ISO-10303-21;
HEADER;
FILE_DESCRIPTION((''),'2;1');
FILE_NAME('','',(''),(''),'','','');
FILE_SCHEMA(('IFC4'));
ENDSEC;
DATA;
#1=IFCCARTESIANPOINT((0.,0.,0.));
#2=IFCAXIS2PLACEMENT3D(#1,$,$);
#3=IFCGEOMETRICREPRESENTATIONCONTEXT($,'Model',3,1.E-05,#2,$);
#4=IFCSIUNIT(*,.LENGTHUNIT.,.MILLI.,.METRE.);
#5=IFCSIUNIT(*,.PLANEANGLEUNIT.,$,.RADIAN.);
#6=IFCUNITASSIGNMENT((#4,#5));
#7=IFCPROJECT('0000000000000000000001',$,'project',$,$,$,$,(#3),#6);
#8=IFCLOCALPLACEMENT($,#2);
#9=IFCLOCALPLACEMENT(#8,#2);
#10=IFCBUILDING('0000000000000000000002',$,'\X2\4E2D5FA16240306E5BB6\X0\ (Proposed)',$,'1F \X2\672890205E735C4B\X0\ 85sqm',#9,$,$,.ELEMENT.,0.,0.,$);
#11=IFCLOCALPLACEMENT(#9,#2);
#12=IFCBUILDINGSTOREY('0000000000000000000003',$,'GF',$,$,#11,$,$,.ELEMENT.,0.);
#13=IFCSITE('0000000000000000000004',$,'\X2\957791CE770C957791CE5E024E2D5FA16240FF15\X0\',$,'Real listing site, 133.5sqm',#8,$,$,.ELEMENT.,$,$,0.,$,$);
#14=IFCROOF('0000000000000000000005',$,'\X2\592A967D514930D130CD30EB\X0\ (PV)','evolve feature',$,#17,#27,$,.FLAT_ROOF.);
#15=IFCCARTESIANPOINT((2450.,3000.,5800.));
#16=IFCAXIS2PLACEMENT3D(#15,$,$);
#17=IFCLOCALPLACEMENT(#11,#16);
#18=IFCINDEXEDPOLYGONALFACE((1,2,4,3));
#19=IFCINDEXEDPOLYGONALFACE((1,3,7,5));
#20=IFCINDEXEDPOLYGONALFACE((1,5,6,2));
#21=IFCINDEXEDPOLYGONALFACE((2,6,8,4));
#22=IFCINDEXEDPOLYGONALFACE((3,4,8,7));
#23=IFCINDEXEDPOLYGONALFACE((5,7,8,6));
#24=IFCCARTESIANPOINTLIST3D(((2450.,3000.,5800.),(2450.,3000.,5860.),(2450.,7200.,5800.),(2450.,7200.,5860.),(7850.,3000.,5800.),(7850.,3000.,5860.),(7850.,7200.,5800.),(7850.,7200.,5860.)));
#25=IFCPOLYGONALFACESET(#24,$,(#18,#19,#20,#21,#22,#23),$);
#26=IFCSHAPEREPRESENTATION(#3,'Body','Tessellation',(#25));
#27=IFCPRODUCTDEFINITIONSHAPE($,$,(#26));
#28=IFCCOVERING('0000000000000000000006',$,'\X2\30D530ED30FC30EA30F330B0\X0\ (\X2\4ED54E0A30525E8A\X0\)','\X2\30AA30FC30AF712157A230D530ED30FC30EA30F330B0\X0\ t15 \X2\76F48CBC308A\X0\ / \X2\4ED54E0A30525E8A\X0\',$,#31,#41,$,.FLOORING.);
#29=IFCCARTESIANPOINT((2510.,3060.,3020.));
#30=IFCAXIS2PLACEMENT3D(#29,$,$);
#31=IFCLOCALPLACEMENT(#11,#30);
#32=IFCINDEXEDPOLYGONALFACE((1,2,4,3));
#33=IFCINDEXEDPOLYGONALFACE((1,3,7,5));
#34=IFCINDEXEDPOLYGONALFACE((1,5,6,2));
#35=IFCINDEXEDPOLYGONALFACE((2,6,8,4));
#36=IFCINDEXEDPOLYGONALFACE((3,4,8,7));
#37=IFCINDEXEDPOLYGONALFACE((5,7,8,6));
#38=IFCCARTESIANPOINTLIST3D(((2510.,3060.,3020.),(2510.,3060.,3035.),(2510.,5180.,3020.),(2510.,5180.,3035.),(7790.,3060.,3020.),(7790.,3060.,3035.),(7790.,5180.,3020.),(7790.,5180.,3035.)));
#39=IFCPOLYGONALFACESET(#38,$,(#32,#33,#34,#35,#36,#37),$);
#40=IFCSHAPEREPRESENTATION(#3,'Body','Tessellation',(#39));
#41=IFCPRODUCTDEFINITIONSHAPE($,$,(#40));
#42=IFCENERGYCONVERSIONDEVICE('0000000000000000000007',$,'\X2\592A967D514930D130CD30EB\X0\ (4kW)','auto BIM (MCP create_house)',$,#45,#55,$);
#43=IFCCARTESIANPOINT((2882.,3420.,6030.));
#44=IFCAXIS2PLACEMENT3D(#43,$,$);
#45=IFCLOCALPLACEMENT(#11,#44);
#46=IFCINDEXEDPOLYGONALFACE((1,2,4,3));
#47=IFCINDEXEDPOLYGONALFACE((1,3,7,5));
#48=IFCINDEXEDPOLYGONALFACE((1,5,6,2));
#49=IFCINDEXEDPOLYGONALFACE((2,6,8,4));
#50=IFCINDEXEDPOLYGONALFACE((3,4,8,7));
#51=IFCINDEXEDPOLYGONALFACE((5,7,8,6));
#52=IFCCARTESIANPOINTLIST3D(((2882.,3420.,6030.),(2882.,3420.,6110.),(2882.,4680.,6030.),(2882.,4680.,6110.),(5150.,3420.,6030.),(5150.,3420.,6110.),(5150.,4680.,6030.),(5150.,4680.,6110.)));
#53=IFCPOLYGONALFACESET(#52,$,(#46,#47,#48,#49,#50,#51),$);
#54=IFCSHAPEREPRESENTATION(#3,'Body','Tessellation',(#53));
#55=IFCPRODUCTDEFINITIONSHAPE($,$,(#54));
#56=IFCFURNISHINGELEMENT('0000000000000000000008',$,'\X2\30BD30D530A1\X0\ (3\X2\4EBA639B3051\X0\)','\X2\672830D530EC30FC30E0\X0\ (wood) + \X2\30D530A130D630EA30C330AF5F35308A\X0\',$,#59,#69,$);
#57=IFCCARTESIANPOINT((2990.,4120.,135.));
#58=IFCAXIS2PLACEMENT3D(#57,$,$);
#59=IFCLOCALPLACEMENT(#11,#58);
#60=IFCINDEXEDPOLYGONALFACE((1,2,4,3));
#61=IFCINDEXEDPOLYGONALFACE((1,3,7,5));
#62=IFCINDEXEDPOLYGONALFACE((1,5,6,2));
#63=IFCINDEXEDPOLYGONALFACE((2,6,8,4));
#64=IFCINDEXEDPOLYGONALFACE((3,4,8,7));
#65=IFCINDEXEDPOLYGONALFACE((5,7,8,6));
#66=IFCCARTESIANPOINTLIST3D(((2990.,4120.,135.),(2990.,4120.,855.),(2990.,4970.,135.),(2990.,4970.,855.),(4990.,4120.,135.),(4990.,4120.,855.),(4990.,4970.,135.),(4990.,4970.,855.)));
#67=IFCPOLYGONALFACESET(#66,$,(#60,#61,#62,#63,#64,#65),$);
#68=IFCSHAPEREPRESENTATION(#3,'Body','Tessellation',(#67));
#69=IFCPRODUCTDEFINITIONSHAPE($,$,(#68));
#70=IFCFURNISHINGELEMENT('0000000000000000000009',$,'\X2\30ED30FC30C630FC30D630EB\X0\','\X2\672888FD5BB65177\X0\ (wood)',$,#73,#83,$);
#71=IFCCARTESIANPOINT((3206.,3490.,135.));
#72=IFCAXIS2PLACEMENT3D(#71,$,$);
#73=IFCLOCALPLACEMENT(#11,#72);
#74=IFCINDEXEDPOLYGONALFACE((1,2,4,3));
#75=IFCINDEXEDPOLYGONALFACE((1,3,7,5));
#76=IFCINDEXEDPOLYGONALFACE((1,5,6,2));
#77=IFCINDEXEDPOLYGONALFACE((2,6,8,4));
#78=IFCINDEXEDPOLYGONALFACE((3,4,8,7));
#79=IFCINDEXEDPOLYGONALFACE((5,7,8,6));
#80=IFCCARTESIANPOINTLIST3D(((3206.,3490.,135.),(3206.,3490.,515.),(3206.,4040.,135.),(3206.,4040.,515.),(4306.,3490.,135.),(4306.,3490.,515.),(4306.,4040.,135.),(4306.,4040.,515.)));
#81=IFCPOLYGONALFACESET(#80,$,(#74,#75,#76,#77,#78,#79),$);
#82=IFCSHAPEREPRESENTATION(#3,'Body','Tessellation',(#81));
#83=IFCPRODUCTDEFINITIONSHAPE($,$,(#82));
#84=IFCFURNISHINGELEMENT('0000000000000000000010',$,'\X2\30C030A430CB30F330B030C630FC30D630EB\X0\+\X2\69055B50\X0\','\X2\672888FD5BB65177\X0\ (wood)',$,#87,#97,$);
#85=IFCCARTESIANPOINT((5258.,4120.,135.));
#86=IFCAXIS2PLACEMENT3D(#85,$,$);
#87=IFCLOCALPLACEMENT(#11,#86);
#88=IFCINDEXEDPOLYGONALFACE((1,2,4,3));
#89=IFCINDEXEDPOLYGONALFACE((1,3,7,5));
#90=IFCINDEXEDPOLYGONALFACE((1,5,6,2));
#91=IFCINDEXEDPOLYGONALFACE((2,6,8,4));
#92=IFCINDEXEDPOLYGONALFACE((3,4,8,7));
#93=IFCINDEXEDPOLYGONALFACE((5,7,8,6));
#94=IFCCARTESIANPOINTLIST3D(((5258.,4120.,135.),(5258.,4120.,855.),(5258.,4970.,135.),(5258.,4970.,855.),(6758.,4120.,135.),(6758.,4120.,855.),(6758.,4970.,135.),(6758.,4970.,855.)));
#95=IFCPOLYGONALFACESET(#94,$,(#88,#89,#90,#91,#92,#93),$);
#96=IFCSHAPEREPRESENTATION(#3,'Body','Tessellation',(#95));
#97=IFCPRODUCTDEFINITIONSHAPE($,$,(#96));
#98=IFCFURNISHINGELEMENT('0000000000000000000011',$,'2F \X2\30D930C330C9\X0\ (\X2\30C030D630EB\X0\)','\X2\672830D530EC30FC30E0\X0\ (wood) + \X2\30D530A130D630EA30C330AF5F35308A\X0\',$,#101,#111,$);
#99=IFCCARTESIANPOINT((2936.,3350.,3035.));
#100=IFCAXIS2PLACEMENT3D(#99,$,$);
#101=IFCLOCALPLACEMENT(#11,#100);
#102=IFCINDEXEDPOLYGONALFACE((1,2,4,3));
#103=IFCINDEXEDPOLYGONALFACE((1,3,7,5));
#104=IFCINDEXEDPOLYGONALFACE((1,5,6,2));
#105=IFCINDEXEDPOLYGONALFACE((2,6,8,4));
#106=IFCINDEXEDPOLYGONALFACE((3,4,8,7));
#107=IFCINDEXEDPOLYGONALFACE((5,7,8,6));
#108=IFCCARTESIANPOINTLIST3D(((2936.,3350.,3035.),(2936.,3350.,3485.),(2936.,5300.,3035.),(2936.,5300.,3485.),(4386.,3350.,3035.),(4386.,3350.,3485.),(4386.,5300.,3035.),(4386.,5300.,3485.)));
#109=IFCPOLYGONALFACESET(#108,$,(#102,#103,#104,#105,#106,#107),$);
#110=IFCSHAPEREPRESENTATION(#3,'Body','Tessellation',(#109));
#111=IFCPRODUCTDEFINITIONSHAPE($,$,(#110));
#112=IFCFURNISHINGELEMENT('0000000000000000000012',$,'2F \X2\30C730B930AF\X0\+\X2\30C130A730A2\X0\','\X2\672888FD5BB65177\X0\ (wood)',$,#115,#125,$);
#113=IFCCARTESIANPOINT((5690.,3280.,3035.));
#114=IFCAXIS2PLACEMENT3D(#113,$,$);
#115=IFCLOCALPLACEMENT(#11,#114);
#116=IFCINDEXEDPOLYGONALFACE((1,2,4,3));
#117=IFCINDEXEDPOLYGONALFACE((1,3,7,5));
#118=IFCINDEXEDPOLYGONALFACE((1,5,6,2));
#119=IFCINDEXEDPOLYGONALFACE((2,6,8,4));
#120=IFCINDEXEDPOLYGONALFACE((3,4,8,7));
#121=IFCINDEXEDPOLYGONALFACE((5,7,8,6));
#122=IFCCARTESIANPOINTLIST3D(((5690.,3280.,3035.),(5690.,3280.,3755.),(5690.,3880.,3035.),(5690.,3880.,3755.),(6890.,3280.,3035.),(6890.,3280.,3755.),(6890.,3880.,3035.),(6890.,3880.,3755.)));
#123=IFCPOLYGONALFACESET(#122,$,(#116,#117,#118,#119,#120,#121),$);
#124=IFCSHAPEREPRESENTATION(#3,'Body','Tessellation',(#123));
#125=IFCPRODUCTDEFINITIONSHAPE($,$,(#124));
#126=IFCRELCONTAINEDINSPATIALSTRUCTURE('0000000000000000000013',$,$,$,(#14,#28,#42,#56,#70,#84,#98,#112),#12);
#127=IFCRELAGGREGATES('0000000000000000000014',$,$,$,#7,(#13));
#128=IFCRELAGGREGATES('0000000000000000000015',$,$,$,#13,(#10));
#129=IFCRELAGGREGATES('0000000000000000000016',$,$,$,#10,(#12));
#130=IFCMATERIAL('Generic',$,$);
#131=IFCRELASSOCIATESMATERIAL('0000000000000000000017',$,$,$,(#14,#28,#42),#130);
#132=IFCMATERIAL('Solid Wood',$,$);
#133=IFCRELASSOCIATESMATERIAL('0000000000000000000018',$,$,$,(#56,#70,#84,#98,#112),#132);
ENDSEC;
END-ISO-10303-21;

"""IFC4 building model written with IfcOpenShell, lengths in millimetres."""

from ifc_helpers import new_model, si_unit, frame, frame_2d, origin, place, context, project, spatial, rectangle, extrude, material, element, save


model = new_model("IFC4")

# Units and contexts
model_context = context("Model", 3, precision=1e-05, world=origin())
ifc_project = project(units=[si_unit("LENGTHUNIT", "METRE", prefix="MILLI"), si_unit("PLANEANGLEUNIT", "RADIAN")], contexts=[model_context])

# Site, building, storey
site_placement = place(None, origin())
site = spatial("IfcSite", under=ifc_project, at=site_placement, Name="長野県長野市中御所５", ObjectType="Real listing site, 133.5sqm", CompositionType="ELEMENT", RefElevation=0.0)
building_placement = place(site_placement, origin())
building = spatial("IfcBuilding", under=site, at=building_placement, Name="中御所の家 (Proposed)", ObjectType="1F 木造平屋 85sqm", CompositionType="ELEMENT", ElevationOfRefHeight=0.0, ElevationOfTerrain=0.0)
storey_placement = place(building_placement, origin())
storey = spatial("IfcBuildingStorey", under=building, at=storey_placement, Name="GF", CompositionType="ELEMENT", Elevation=0.0)

# Shared definitions
ifc_material_1 = material(Name="Solid Wood")

# Roof
ifc_material_2 = material(Name="Generic")
roof_1_placement = place(storey_placement, frame((2450.0, 3000.0, 5800.0)))
element("IfcRoof", 1, at=roof_1_placement, inside=storey, material=ifc_material_2, Name="太陽光パネル (PV)", Description="evolve feature", PredefinedType="FLAT_ROOF", context=model_context, shape_type="SweptSolid", body=[
    extrude(rectangle(XDim=5400.0, YDim=4200.0, at=frame_2d((2700.0, 2100.0))), frame((2450.0, 3000.0, 5800.0)), (0.0, 0.0, 1.0), 60.0),
])

# Covering
covering_placement = place(storey_placement, frame((2510.0, 3060.0, 3020.0)))
element("IfcCovering", 2, at=covering_placement, inside=storey, material=ifc_material_2, Name="フローリング (仕上げ床)", Description="オーク無垢フローリング t15 直貼り / 仕上げ床", PredefinedType="FLOORING", context=model_context, shape_type="SweptSolid", body=[
    extrude(rectangle(XDim=5280.0, YDim=2120.0, at=frame_2d((2640.0, 1060.0))), frame((2510.0, 3060.0, 3020.0)), (0.0, 0.0, 1.0), 15.0),
])

# Energy conversion device
energy_conversion_device_placement = place(storey_placement, frame((2882.0, 3420.0, 6030.0)))
element("IfcEnergyConversionDevice", 3, at=energy_conversion_device_placement, inside=storey, material=ifc_material_2, Name="太陽光パネル (4kW)", Description="auto BIM (MCP create_house)", context=model_context, shape_type="SweptSolid", body=[
    extrude(rectangle(XDim=2268.0, YDim=1260.0, at=frame_2d((1134.0, 630.0))), frame((2882.0, 3420.0, 6030.0)), (0.0, 0.0, 1.0), 80.0),
])

# Furnishing elements
furnishing_1_placement = place(storey_placement, frame((2990.0, 4120.0, 135.0)))
element("IfcFurnishingElement", 4, at=furnishing_1_placement, inside=storey, material=ifc_material_1, Name="ソファ (3人掛け)", Description="木フレーム (wood) + ファブリック張り", context=model_context, shape_type="SweptSolid", body=[
    extrude(rectangle(XDim=2000.0, YDim=850.0, at=frame_2d((1000.0, 425.0))), frame((2990.0, 4120.0, 135.0)), (0.0, 0.0, 1.0), 720.0),
])
furnishing_2_placement = place(storey_placement, frame((3206.0, 3490.0, 135.0)))
element("IfcFurnishingElement", 5, at=furnishing_2_placement, inside=storey, material=ifc_material_1, Name="ローテーブル", Description="木製家具 (wood)", context=model_context, shape_type="SweptSolid", body=[
    extrude(rectangle(XDim=1100.0, YDim=550.0, at=frame_2d((550.0, 275.0))), frame((3206.0, 3490.0, 135.0)), (0.0, 0.0, 1.0), 380.0),
])
furnishing_3_placement = place(storey_placement, frame((5258.0, 4120.0, 135.0)))
element("IfcFurnishingElement", 6, at=furnishing_3_placement, inside=storey, material=ifc_material_1, Name="ダイニングテーブル+椅子", Description="木製家具 (wood)", context=model_context, shape_type="SweptSolid", body=[
    extrude(rectangle(XDim=1500.0, YDim=850.0, at=frame_2d((750.0, 425.0))), frame((5258.0, 4120.0, 135.0)), (0.0, 0.0, 1.0), 720.0),
])
furnishing_4_placement = place(storey_placement, frame((2936.0, 3350.0, 3035.0)))
element("IfcFurnishingElement", 7, at=furnishing_4_placement, inside=storey, material=ifc_material_1, Name="2F ベッド (ダブル)", Description="木フレーム (wood) + ファブリック張り", context=model_context, shape_type="SweptSolid", body=[
    extrude(rectangle(XDim=1450.0, YDim=1950.0, at=frame_2d((725.0, 975.0))), frame((2936.0, 3350.0, 3035.0)), (0.0, 0.0, 1.0), 450.0),
])
furnishing_5_placement = place(storey_placement, frame((5690.0, 3280.0, 3035.0)))
element("IfcFurnishingElement", 8, at=furnishing_5_placement, inside=storey, material=ifc_material_1, Name="2F デスク+チェア", Description="木製家具 (wood)", context=model_context, shape_type="SweptSolid", body=[
    extrude(rectangle(XDim=1200.0, YDim=600.0, at=frame_2d((600.0, 300.0))), frame((5690.0, 3280.0, 3035.0)), (0.0, 0.0, 1.0), 720.0),
])

save(model, "model.ifc")
